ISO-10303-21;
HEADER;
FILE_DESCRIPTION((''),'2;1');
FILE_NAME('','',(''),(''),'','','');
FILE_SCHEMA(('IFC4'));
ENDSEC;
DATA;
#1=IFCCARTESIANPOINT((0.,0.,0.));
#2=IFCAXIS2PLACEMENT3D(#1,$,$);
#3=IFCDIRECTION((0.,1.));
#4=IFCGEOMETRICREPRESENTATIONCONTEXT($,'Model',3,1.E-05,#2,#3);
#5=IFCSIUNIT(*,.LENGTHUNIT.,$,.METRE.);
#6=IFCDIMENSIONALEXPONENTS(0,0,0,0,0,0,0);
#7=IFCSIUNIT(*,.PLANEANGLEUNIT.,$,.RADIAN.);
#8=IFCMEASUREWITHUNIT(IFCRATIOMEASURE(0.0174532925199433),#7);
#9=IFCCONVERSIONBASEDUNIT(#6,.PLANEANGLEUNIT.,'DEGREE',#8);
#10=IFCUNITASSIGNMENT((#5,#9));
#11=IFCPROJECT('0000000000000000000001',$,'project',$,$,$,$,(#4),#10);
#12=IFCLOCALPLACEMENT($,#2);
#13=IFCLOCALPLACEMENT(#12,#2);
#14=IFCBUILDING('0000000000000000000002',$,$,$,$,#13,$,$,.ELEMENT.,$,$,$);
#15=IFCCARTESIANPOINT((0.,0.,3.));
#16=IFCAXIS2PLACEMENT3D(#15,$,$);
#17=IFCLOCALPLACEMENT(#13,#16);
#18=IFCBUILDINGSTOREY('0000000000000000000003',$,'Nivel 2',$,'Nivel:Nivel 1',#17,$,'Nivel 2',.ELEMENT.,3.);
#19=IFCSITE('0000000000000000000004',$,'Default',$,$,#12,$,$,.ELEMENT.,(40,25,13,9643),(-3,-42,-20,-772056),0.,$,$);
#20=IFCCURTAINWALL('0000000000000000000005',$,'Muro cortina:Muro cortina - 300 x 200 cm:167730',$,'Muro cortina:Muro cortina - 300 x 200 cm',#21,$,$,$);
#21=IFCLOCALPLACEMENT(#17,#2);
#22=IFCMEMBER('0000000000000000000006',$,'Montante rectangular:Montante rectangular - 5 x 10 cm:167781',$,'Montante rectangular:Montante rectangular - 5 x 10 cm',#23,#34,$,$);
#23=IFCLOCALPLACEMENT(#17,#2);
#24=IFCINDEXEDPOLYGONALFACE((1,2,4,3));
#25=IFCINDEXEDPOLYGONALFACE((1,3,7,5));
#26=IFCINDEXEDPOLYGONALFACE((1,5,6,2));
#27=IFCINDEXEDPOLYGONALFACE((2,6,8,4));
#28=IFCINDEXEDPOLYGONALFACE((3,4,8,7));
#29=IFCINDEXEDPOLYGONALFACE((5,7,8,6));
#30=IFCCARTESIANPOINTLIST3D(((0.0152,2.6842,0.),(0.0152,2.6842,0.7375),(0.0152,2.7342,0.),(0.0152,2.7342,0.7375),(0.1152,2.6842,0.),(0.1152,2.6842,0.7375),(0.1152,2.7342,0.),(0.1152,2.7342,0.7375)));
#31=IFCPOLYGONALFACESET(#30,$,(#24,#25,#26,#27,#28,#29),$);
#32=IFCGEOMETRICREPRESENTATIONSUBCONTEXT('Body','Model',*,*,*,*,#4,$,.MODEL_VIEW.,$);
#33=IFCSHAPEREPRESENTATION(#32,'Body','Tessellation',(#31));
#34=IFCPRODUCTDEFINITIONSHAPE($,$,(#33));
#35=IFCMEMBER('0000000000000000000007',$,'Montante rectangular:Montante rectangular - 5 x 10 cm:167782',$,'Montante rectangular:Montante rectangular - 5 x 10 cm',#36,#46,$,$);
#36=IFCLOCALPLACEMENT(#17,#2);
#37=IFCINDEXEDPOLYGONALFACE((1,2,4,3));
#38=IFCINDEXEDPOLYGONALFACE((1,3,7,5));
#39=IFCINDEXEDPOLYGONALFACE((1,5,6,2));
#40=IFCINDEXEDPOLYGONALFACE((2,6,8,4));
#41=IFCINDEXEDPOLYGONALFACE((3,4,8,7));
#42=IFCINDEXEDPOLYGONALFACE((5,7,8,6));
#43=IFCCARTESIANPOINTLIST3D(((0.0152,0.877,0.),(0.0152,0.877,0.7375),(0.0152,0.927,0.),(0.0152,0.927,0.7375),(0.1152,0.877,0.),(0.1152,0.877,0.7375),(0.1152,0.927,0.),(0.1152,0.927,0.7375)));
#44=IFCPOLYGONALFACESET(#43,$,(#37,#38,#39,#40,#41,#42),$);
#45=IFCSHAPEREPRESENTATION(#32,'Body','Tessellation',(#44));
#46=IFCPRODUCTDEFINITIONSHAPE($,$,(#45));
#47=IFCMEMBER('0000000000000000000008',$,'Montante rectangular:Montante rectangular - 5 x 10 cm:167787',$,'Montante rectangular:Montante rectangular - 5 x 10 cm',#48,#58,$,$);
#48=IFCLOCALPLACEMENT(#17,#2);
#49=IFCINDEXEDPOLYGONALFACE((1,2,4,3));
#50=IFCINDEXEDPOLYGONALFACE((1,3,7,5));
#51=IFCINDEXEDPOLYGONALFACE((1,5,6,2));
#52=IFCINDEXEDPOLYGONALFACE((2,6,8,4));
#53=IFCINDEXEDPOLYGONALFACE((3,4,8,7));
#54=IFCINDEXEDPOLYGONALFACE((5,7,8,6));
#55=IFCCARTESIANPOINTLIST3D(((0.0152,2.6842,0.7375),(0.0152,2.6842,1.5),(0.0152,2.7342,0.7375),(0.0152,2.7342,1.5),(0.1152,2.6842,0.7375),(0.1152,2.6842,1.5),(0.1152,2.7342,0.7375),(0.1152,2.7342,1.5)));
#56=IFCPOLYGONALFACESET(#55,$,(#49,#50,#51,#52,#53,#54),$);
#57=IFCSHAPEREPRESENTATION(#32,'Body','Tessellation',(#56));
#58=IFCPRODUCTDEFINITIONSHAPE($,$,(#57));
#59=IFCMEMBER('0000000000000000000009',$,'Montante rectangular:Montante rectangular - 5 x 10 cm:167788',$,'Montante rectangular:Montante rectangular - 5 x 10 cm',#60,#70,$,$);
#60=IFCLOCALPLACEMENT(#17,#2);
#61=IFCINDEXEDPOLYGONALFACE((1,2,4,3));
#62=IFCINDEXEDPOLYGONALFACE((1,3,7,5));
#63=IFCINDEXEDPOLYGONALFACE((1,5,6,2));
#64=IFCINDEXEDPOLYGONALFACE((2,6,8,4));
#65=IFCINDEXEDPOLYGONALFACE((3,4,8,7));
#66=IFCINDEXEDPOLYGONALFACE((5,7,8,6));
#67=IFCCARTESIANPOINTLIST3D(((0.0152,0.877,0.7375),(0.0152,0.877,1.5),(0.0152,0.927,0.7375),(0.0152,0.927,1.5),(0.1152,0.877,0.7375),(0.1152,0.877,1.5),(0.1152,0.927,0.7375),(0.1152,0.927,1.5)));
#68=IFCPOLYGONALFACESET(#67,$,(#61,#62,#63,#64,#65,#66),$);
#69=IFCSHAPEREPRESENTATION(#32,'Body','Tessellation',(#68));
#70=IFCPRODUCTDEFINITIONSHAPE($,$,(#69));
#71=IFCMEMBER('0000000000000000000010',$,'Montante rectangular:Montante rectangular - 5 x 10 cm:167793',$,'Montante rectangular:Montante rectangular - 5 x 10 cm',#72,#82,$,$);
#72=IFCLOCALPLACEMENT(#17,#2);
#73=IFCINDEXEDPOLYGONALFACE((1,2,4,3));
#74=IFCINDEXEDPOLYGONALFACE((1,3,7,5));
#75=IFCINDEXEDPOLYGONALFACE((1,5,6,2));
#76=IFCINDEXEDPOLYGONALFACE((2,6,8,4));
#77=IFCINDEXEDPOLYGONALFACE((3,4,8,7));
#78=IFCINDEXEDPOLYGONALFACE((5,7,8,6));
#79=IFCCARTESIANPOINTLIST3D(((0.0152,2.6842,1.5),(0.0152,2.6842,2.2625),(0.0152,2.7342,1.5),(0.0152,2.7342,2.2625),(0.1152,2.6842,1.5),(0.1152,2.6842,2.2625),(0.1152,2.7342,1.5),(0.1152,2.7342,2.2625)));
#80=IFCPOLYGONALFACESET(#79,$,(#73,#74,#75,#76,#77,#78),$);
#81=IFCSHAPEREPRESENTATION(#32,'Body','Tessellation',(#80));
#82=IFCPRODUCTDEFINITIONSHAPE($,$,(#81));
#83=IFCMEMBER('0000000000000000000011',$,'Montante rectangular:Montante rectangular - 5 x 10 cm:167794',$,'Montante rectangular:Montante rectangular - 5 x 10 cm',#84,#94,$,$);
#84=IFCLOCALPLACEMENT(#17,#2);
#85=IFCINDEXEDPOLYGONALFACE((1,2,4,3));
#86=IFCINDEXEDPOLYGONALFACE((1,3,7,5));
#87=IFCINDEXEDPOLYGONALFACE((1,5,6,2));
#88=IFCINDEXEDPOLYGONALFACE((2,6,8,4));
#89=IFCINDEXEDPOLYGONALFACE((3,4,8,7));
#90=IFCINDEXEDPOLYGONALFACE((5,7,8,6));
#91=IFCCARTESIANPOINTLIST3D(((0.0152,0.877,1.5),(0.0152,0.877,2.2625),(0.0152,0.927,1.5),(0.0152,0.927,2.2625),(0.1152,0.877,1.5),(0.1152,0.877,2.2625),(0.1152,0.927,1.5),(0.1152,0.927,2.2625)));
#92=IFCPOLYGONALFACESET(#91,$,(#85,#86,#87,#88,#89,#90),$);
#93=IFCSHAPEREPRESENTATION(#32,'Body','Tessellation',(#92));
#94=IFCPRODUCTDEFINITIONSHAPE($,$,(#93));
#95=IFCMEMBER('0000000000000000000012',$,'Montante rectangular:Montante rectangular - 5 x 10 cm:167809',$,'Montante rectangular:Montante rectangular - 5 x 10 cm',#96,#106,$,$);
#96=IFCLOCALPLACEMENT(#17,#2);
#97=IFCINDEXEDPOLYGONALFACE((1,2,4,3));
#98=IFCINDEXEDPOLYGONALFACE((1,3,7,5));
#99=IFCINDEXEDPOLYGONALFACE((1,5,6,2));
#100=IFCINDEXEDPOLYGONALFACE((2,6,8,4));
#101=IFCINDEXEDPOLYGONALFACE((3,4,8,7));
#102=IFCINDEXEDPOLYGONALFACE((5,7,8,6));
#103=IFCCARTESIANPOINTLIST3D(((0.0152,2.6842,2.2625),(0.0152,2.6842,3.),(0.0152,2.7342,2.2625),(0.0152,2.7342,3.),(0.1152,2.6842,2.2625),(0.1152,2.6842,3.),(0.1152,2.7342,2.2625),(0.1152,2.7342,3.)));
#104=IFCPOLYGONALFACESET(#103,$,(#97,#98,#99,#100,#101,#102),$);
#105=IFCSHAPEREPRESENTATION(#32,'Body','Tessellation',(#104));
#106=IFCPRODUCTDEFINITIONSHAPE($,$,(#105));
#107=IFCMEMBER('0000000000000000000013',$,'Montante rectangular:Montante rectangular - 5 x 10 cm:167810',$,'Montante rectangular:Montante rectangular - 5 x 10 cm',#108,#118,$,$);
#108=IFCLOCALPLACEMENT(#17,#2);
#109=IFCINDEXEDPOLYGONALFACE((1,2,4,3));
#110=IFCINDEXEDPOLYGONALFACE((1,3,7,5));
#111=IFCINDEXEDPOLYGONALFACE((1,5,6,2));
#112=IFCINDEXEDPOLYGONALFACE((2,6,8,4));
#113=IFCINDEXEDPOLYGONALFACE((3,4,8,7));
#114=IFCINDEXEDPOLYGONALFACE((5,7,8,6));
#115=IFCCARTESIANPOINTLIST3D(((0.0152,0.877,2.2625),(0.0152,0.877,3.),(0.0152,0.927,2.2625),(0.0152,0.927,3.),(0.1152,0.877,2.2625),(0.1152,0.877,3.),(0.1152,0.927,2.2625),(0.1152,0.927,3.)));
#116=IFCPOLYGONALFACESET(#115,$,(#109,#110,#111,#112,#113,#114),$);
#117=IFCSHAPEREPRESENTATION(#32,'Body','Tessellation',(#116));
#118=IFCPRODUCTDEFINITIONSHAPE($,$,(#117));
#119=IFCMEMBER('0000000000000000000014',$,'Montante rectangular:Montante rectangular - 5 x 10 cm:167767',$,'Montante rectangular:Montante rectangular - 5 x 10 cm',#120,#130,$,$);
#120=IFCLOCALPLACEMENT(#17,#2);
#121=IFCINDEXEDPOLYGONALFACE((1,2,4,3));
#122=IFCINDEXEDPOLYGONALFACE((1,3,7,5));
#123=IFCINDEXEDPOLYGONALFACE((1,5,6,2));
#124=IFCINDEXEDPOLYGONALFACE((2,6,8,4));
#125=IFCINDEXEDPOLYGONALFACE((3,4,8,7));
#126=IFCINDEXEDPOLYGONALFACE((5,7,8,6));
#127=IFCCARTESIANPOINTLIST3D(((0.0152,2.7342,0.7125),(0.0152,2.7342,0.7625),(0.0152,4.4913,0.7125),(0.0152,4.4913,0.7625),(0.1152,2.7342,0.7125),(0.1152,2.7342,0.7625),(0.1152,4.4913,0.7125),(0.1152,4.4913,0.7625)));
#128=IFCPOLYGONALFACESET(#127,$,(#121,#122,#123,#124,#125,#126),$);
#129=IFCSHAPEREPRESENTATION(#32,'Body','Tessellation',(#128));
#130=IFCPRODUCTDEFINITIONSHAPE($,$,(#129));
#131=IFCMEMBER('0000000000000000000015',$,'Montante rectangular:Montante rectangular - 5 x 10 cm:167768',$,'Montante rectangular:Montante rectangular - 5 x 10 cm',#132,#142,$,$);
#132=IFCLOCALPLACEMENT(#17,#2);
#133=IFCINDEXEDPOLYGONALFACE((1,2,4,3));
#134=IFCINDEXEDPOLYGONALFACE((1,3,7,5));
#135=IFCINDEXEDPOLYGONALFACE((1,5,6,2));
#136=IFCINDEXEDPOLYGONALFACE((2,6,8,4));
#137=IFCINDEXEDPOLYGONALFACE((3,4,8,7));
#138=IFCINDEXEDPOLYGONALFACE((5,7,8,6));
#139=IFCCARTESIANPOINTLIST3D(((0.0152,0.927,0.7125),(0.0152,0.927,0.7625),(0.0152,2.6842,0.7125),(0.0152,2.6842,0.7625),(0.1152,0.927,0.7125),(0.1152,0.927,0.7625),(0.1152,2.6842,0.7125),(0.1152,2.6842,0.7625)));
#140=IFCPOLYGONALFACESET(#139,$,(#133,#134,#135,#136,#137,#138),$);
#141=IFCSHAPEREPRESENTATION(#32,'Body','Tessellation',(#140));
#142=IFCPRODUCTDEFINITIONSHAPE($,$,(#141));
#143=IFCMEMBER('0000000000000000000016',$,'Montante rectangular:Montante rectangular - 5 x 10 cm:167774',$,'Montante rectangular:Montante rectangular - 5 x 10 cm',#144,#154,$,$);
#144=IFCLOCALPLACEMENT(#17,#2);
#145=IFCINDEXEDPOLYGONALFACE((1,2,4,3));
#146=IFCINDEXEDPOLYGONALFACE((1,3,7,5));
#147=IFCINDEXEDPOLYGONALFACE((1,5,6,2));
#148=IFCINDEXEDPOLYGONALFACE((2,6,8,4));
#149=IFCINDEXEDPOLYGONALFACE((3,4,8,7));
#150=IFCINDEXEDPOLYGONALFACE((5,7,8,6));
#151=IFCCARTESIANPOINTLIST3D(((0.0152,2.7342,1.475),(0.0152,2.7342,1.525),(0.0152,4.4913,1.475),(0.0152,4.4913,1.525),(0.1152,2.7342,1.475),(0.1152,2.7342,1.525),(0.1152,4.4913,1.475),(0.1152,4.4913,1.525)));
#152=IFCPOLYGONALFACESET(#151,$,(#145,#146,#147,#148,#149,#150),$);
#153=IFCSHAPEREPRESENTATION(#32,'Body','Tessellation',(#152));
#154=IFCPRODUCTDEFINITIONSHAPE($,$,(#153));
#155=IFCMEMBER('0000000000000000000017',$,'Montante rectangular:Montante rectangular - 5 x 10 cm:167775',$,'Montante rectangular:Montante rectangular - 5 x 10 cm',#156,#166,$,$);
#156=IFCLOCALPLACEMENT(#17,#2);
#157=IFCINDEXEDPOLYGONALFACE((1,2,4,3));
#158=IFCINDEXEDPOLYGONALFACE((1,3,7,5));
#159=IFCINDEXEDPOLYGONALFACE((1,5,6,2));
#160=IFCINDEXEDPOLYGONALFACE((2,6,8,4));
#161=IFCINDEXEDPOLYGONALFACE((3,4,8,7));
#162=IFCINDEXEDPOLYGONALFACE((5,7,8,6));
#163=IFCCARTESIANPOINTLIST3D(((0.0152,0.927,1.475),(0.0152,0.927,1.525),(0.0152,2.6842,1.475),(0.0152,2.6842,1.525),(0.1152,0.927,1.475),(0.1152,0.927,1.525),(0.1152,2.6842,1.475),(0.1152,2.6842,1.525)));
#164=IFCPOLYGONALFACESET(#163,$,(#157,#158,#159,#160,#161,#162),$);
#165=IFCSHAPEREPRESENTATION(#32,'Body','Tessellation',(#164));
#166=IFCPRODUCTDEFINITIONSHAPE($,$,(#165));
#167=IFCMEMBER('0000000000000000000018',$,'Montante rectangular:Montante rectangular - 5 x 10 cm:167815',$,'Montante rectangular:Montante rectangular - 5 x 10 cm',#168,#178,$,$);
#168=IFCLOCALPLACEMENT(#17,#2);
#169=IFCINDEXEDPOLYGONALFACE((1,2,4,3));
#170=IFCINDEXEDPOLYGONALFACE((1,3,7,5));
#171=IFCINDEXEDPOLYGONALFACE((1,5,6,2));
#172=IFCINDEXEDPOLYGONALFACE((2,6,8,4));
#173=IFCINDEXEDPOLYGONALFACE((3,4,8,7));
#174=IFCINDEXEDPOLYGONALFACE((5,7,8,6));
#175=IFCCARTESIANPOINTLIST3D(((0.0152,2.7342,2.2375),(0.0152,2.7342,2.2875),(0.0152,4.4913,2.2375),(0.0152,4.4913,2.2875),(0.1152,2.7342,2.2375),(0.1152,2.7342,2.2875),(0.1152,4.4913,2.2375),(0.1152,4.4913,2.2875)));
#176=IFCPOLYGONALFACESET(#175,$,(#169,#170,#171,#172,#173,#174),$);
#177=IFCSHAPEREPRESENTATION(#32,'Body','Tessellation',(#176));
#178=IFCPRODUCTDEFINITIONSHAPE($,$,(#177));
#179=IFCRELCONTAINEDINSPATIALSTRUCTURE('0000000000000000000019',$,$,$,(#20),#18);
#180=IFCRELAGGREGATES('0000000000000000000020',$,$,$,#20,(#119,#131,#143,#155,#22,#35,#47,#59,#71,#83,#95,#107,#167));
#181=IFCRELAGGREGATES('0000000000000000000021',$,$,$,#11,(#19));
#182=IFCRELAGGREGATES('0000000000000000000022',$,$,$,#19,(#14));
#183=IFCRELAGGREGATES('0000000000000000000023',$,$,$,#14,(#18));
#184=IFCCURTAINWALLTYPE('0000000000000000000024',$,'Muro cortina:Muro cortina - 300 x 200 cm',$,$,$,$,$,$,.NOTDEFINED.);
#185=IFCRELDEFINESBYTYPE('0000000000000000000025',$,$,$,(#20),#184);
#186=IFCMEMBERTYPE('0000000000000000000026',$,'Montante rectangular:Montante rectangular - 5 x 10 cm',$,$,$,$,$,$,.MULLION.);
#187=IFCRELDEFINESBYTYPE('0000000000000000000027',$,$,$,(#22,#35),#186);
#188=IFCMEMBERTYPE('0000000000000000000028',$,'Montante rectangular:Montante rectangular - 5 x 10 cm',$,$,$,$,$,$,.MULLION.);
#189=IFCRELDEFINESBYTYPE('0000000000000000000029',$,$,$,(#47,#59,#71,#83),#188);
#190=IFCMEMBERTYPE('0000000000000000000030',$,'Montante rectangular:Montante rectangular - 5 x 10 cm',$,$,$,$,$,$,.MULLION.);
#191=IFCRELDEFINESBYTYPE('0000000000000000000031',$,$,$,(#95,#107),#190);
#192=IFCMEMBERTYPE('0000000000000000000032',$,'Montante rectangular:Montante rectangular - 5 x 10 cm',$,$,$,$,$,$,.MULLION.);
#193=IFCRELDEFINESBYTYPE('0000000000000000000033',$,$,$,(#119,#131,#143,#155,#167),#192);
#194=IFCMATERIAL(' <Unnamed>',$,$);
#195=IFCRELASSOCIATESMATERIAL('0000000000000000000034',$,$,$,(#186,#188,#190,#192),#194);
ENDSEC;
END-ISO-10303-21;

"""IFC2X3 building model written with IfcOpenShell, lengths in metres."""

from ifc_helpers import new_model, entity, si_unit, converted_unit, direction, frame, origin, origin_2d_with_axis, place, context, subcontext, project, spatial, rectangle, extrude, source, transform, mapped, material, type_object, type_shapes, element, aggregate, save


model = new_model("IFC2X3")

# Units and contexts
model_context = context("Model", 3, precision=1e-05, world=origin(), true_north=direction((0.0, 1.0)))
body_context = subcontext(model_context, "Body", "Model", "MODEL_VIEW")
ifc_project = project(units=[si_unit("LENGTHUNIT", "METRE"), converted_unit("PLANEANGLEUNIT", "DEGREE", entity("IfcRatioMeasure", 0.0174532925199433), si_unit("PLANEANGLEUNIT", "RADIAN"), dimensions=[0, 0, 0, 0, 0, 0, 0])], contexts=[model_context])

# Site, building, storey
site_placement = place(None, origin())
site = spatial("IfcSite", under=ifc_project, at=site_placement, Name="Default", CompositionType="ELEMENT", RefLatitude=(40, 25, 13, 9643), RefLongitude=(-3, -42, -20, -772056), RefElevation=0.0)
building_placement = place(site_placement, origin())
building = spatial("IfcBuilding", under=site, at=building_placement, CompositionType="ELEMENT")
storey_placement = place(building_placement, frame((0.0, 0.0, 3.0)))
storey = spatial("IfcBuildingStorey", under=building, at=storey_placement, Name="Nivel 2", ObjectType="Nivel:Nivel 1", LongName="Nivel 2", CompositionType="ELEMENT", Elevation=3.0)

# Curtain wall, members
curtain_wall_type = type_object("IfcCurtainWallType", Name="Muro cortina:Muro cortina - 300 x 200 cm", PredefinedType="NOTDEFINED")
curtain_wall_placement = place(storey_placement, frame((0.0, 0.0, -3.0)))
curtain_wall = element("IfcCurtainWall", 1, at=curtain_wall_placement, inside=storey, type_object=curtain_wall_type, Name="Muro cortina:Muro cortina - 300 x 200 cm:167730", ObjectType="Muro cortina:Muro cortina - 300 x 200 cm")
ifc_material_1 = material(Name=" <Unnamed>")
member_type_1 = type_object("IfcMemberType", Name="Montante rectangular:Montante rectangular - 5 x 10 cm", PredefinedType="MULLION", material=ifc_material_1)
shared_shape_1 = source(origin(), body_context, "Body", "SweptSolid", [
    extrude(rectangle(XDim=0.1, YDim=0.05, at=origin_2d_with_axis()), frame((0.0, 0.0, -0.7375), z_axis=(0.0, 0.0, 1.0), x_axis=(0.0, -1.0, 0.0)), (0.0, 0.0, 1.0), 0.7375),
])
type_shapes(member_type_1, [shared_shape_1])
member_1_placement = place(storey_placement, frame((0.0652, 2.7092, 0.0), z_axis=(0.0, 0.0, -1.0), x_axis=(0.0, -1.0, 0.0)))
member_1 = element("IfcMember", 2, at=member_1_placement, type_object=member_type_1, Name="Montante rectangular:Montante rectangular - 5 x 10 cm:167781", ObjectType="Montante rectangular:Montante rectangular - 5 x 10 cm", context=body_context, shape_type="MappedRepresentation", body=[
    mapped(shared_shape_1, transform((0.0, 0.0, 0.0), scale=1.0)),
])
member_2_placement = place(storey_placement, frame((0.0652, 0.902, 0.0), z_axis=(0.0, 0.0, -1.0), x_axis=(0.0, -1.0, 0.0)))
member_2 = element("IfcMember", 3, at=member_2_placement, type_object=member_type_1, Name="Montante rectangular:Montante rectangular - 5 x 10 cm:167782", ObjectType="Montante rectangular:Montante rectangular - 5 x 10 cm", context=body_context, shape_type="MappedRepresentation", body=[
    mapped(shared_shape_1, transform((0.0, 0.0, 0.0), scale=1.0)),
])
member_type_2 = type_object("IfcMemberType", Name="Montante rectangular:Montante rectangular - 5 x 10 cm", PredefinedType="MULLION", material=ifc_material_1)
shared_shape_2 = source(origin(), body_context, "Body", "SweptSolid", [
    extrude(rectangle(XDim=0.1, YDim=0.05, at=origin_2d_with_axis()), frame((0.0, 0.0, -0.7625), z_axis=(0.0, 0.0, 1.0), x_axis=(0.0, -1.0, 0.0)), (0.0, 0.0, 1.0), 0.7625),
])
type_shapes(member_type_2, [shared_shape_2])
member_3_placement = place(storey_placement, frame((0.0652, 2.7092, 0.7375), z_axis=(0.0, 0.0, -1.0), x_axis=(0.0, -1.0, 0.0)))
member_3 = element("IfcMember", 4, at=member_3_placement, type_object=member_type_2, Name="Montante rectangular:Montante rectangular - 5 x 10 cm:167787", ObjectType="Montante rectangular:Montante rectangular - 5 x 10 cm", context=body_context, shape_type="MappedRepresentation", body=[
    mapped(shared_shape_2, transform((0.0, 0.0, 0.0), scale=1.0)),
])
member_4_placement = place(storey_placement, frame((0.0652, 0.902, 0.7375), z_axis=(0.0, 0.0, -1.0), x_axis=(0.0, -1.0, 0.0)))
member_4 = element("IfcMember", 5, at=member_4_placement, type_object=member_type_2, Name="Montante rectangular:Montante rectangular - 5 x 10 cm:167788", ObjectType="Montante rectangular:Montante rectangular - 5 x 10 cm", context=body_context, shape_type="MappedRepresentation", body=[
    mapped(shared_shape_2, transform((0.0, 0.0, 0.0), scale=1.0)),
])
member_5_placement = place(storey_placement, frame((0.0652, 2.7092, 1.5), z_axis=(0.0, 0.0, -1.0), x_axis=(0.0, -1.0, 0.0)))
member_5 = element("IfcMember", 6, at=member_5_placement, type_object=member_type_2, Name="Montante rectangular:Montante rectangular - 5 x 10 cm:167793", ObjectType="Montante rectangular:Montante rectangular - 5 x 10 cm", context=body_context, shape_type="MappedRepresentation", body=[
    mapped(shared_shape_2, transform((0.0, 0.0, 0.0), scale=1.0)),
])
member_6_placement = place(storey_placement, frame((0.0652, 0.902, 1.5), z_axis=(0.0, 0.0, -1.0), x_axis=(0.0, -1.0, 0.0)))
member_6 = element("IfcMember", 7, at=member_6_placement, type_object=member_type_2, Name="Montante rectangular:Montante rectangular - 5 x 10 cm:167794", ObjectType="Montante rectangular:Montante rectangular - 5 x 10 cm", context=body_context, shape_type="MappedRepresentation", body=[
    mapped(shared_shape_2, transform((0.0, 0.0, 0.0), scale=1.0)),
])
member_type_3 = type_object("IfcMemberType", Name="Montante rectangular:Montante rectangular - 5 x 10 cm", PredefinedType="MULLION", material=ifc_material_1)
shared_shape_3 = source(origin(), body_context, "Body", "SweptSolid", [
    extrude(rectangle(XDim=0.1, YDim=0.05, at=origin_2d_with_axis()), frame((0.0, 0.0, -0.7375), z_axis=(0.0, 0.0, 1.0), x_axis=(0.0, -1.0, 0.0)), (0.0, 0.0, 1.0), 0.7375),
])
type_shapes(member_type_3, [shared_shape_3])
member_7_placement = place(storey_placement, frame((0.0652, 2.7092, 2.2625), z_axis=(0.0, 0.0, -1.0), x_axis=(0.0, -1.0, 0.0)))
member_7 = element("IfcMember", 8, at=member_7_placement, type_object=member_type_3, Name="Montante rectangular:Montante rectangular - 5 x 10 cm:167809", ObjectType="Montante rectangular:Montante rectangular - 5 x 10 cm", context=body_context, shape_type="MappedRepresentation", body=[
    mapped(shared_shape_3, transform((0.0, 0.0, 0.0), scale=1.0)),
])
member_8_placement = place(storey_placement, frame((0.0652, 0.902, 2.2625), z_axis=(0.0, 0.0, -1.0), x_axis=(0.0, -1.0, 0.0)))
member_8 = element("IfcMember", 9, at=member_8_placement, type_object=member_type_3, Name="Montante rectangular:Montante rectangular - 5 x 10 cm:167810", ObjectType="Montante rectangular:Montante rectangular - 5 x 10 cm", context=body_context, shape_type="MappedRepresentation", body=[
    mapped(shared_shape_3, transform((0.0, 0.0, 0.0), scale=1.0)),
])
member_type_4 = type_object("IfcMemberType", Name="Montante rectangular:Montante rectangular - 5 x 10 cm", PredefinedType="MULLION", material=ifc_material_1)
shared_shape_4 = source(origin(), body_context, "Body", "SweptSolid", [
    extrude(rectangle(XDim=0.1, YDim=0.05, at=origin_2d_with_axis()), frame((0.0, 0.0, -1.7571), z_axis=(0.0, 0.0, 1.0), x_axis=(0.0, -1.0, 0.0)), (0.0, 0.0, 1.0), 1.7571),
])
type_shapes(member_type_4, [shared_shape_4])
member_9_placement = place(storey_placement, frame((0.0652, 2.7342, 0.7375), z_axis=(0.0, -1.0, 0.0), x_axis=(0.0, 0.0, 1.0)))
member_9 = element("IfcMember", 10, at=member_9_placement, type_object=member_type_4, Name="Montante rectangular:Montante rectangular - 5 x 10 cm:167767", ObjectType="Montante rectangular:Montante rectangular - 5 x 10 cm", context=body_context, shape_type="MappedRepresentation", body=[
    mapped(shared_shape_4, transform((0.0, 0.0, 0.0), scale=1.0)),
])
member_10_placement = place(storey_placement, frame((0.0652, 0.927, 0.7375), z_axis=(0.0, -1.0, 0.0), x_axis=(0.0, 0.0, 1.0)))
member_10 = element("IfcMember", 11, at=member_10_placement, type_object=member_type_4, Name="Montante rectangular:Montante rectangular - 5 x 10 cm:167768", ObjectType="Montante rectangular:Montante rectangular - 5 x 10 cm", context=body_context, shape_type="MappedRepresentation", body=[
    mapped(shared_shape_4, transform((0.0, 0.0, 0.0), scale=1.0)),
])
member_11_placement = place(storey_placement, frame((0.0652, 2.7342, 1.5), z_axis=(0.0, -1.0, 0.0), x_axis=(0.0, 0.0, 1.0)))
member_11 = element("IfcMember", 12, at=member_11_placement, type_object=member_type_4, Name="Montante rectangular:Montante rectangular - 5 x 10 cm:167774", ObjectType="Montante rectangular:Montante rectangular - 5 x 10 cm", context=body_context, shape_type="MappedRepresentation", body=[
    mapped(shared_shape_4, transform((0.0, 0.0, 0.0), scale=1.0)),
])
member_12_placement = place(storey_placement, frame((0.0652, 0.927, 1.5), z_axis=(0.0, -1.0, 0.0), x_axis=(0.0, 0.0, 1.0)))
member_12 = element("IfcMember", 13, at=member_12_placement, type_object=member_type_4, Name="Montante rectangular:Montante rectangular - 5 x 10 cm:167775", ObjectType="Montante rectangular:Montante rectangular - 5 x 10 cm", context=body_context, shape_type="MappedRepresentation", body=[
    mapped(shared_shape_4, transform((0.0, 0.0, 0.0), scale=1.0)),
])
member_13_placement = place(storey_placement, frame((0.0652, 2.7342, 2.2625), z_axis=(0.0, -1.0, 0.0), x_axis=(0.0, 0.0, 1.0)))
member_13 = element("IfcMember", 14, at=member_13_placement, type_object=member_type_4, Name="Montante rectangular:Montante rectangular - 5 x 10 cm:167815", ObjectType="Montante rectangular:Montante rectangular - 5 x 10 cm", context=body_context, shape_type="MappedRepresentation", body=[
    mapped(shared_shape_4, transform((0.0, 0.0, 0.0), scale=1.0)),
])
aggregate(curtain_wall, [member_9, member_10, member_11, member_12, member_1, member_2, member_3, member_4, member_5, member_6, member_7, member_8, member_13])

save(model, "model.ifc")
